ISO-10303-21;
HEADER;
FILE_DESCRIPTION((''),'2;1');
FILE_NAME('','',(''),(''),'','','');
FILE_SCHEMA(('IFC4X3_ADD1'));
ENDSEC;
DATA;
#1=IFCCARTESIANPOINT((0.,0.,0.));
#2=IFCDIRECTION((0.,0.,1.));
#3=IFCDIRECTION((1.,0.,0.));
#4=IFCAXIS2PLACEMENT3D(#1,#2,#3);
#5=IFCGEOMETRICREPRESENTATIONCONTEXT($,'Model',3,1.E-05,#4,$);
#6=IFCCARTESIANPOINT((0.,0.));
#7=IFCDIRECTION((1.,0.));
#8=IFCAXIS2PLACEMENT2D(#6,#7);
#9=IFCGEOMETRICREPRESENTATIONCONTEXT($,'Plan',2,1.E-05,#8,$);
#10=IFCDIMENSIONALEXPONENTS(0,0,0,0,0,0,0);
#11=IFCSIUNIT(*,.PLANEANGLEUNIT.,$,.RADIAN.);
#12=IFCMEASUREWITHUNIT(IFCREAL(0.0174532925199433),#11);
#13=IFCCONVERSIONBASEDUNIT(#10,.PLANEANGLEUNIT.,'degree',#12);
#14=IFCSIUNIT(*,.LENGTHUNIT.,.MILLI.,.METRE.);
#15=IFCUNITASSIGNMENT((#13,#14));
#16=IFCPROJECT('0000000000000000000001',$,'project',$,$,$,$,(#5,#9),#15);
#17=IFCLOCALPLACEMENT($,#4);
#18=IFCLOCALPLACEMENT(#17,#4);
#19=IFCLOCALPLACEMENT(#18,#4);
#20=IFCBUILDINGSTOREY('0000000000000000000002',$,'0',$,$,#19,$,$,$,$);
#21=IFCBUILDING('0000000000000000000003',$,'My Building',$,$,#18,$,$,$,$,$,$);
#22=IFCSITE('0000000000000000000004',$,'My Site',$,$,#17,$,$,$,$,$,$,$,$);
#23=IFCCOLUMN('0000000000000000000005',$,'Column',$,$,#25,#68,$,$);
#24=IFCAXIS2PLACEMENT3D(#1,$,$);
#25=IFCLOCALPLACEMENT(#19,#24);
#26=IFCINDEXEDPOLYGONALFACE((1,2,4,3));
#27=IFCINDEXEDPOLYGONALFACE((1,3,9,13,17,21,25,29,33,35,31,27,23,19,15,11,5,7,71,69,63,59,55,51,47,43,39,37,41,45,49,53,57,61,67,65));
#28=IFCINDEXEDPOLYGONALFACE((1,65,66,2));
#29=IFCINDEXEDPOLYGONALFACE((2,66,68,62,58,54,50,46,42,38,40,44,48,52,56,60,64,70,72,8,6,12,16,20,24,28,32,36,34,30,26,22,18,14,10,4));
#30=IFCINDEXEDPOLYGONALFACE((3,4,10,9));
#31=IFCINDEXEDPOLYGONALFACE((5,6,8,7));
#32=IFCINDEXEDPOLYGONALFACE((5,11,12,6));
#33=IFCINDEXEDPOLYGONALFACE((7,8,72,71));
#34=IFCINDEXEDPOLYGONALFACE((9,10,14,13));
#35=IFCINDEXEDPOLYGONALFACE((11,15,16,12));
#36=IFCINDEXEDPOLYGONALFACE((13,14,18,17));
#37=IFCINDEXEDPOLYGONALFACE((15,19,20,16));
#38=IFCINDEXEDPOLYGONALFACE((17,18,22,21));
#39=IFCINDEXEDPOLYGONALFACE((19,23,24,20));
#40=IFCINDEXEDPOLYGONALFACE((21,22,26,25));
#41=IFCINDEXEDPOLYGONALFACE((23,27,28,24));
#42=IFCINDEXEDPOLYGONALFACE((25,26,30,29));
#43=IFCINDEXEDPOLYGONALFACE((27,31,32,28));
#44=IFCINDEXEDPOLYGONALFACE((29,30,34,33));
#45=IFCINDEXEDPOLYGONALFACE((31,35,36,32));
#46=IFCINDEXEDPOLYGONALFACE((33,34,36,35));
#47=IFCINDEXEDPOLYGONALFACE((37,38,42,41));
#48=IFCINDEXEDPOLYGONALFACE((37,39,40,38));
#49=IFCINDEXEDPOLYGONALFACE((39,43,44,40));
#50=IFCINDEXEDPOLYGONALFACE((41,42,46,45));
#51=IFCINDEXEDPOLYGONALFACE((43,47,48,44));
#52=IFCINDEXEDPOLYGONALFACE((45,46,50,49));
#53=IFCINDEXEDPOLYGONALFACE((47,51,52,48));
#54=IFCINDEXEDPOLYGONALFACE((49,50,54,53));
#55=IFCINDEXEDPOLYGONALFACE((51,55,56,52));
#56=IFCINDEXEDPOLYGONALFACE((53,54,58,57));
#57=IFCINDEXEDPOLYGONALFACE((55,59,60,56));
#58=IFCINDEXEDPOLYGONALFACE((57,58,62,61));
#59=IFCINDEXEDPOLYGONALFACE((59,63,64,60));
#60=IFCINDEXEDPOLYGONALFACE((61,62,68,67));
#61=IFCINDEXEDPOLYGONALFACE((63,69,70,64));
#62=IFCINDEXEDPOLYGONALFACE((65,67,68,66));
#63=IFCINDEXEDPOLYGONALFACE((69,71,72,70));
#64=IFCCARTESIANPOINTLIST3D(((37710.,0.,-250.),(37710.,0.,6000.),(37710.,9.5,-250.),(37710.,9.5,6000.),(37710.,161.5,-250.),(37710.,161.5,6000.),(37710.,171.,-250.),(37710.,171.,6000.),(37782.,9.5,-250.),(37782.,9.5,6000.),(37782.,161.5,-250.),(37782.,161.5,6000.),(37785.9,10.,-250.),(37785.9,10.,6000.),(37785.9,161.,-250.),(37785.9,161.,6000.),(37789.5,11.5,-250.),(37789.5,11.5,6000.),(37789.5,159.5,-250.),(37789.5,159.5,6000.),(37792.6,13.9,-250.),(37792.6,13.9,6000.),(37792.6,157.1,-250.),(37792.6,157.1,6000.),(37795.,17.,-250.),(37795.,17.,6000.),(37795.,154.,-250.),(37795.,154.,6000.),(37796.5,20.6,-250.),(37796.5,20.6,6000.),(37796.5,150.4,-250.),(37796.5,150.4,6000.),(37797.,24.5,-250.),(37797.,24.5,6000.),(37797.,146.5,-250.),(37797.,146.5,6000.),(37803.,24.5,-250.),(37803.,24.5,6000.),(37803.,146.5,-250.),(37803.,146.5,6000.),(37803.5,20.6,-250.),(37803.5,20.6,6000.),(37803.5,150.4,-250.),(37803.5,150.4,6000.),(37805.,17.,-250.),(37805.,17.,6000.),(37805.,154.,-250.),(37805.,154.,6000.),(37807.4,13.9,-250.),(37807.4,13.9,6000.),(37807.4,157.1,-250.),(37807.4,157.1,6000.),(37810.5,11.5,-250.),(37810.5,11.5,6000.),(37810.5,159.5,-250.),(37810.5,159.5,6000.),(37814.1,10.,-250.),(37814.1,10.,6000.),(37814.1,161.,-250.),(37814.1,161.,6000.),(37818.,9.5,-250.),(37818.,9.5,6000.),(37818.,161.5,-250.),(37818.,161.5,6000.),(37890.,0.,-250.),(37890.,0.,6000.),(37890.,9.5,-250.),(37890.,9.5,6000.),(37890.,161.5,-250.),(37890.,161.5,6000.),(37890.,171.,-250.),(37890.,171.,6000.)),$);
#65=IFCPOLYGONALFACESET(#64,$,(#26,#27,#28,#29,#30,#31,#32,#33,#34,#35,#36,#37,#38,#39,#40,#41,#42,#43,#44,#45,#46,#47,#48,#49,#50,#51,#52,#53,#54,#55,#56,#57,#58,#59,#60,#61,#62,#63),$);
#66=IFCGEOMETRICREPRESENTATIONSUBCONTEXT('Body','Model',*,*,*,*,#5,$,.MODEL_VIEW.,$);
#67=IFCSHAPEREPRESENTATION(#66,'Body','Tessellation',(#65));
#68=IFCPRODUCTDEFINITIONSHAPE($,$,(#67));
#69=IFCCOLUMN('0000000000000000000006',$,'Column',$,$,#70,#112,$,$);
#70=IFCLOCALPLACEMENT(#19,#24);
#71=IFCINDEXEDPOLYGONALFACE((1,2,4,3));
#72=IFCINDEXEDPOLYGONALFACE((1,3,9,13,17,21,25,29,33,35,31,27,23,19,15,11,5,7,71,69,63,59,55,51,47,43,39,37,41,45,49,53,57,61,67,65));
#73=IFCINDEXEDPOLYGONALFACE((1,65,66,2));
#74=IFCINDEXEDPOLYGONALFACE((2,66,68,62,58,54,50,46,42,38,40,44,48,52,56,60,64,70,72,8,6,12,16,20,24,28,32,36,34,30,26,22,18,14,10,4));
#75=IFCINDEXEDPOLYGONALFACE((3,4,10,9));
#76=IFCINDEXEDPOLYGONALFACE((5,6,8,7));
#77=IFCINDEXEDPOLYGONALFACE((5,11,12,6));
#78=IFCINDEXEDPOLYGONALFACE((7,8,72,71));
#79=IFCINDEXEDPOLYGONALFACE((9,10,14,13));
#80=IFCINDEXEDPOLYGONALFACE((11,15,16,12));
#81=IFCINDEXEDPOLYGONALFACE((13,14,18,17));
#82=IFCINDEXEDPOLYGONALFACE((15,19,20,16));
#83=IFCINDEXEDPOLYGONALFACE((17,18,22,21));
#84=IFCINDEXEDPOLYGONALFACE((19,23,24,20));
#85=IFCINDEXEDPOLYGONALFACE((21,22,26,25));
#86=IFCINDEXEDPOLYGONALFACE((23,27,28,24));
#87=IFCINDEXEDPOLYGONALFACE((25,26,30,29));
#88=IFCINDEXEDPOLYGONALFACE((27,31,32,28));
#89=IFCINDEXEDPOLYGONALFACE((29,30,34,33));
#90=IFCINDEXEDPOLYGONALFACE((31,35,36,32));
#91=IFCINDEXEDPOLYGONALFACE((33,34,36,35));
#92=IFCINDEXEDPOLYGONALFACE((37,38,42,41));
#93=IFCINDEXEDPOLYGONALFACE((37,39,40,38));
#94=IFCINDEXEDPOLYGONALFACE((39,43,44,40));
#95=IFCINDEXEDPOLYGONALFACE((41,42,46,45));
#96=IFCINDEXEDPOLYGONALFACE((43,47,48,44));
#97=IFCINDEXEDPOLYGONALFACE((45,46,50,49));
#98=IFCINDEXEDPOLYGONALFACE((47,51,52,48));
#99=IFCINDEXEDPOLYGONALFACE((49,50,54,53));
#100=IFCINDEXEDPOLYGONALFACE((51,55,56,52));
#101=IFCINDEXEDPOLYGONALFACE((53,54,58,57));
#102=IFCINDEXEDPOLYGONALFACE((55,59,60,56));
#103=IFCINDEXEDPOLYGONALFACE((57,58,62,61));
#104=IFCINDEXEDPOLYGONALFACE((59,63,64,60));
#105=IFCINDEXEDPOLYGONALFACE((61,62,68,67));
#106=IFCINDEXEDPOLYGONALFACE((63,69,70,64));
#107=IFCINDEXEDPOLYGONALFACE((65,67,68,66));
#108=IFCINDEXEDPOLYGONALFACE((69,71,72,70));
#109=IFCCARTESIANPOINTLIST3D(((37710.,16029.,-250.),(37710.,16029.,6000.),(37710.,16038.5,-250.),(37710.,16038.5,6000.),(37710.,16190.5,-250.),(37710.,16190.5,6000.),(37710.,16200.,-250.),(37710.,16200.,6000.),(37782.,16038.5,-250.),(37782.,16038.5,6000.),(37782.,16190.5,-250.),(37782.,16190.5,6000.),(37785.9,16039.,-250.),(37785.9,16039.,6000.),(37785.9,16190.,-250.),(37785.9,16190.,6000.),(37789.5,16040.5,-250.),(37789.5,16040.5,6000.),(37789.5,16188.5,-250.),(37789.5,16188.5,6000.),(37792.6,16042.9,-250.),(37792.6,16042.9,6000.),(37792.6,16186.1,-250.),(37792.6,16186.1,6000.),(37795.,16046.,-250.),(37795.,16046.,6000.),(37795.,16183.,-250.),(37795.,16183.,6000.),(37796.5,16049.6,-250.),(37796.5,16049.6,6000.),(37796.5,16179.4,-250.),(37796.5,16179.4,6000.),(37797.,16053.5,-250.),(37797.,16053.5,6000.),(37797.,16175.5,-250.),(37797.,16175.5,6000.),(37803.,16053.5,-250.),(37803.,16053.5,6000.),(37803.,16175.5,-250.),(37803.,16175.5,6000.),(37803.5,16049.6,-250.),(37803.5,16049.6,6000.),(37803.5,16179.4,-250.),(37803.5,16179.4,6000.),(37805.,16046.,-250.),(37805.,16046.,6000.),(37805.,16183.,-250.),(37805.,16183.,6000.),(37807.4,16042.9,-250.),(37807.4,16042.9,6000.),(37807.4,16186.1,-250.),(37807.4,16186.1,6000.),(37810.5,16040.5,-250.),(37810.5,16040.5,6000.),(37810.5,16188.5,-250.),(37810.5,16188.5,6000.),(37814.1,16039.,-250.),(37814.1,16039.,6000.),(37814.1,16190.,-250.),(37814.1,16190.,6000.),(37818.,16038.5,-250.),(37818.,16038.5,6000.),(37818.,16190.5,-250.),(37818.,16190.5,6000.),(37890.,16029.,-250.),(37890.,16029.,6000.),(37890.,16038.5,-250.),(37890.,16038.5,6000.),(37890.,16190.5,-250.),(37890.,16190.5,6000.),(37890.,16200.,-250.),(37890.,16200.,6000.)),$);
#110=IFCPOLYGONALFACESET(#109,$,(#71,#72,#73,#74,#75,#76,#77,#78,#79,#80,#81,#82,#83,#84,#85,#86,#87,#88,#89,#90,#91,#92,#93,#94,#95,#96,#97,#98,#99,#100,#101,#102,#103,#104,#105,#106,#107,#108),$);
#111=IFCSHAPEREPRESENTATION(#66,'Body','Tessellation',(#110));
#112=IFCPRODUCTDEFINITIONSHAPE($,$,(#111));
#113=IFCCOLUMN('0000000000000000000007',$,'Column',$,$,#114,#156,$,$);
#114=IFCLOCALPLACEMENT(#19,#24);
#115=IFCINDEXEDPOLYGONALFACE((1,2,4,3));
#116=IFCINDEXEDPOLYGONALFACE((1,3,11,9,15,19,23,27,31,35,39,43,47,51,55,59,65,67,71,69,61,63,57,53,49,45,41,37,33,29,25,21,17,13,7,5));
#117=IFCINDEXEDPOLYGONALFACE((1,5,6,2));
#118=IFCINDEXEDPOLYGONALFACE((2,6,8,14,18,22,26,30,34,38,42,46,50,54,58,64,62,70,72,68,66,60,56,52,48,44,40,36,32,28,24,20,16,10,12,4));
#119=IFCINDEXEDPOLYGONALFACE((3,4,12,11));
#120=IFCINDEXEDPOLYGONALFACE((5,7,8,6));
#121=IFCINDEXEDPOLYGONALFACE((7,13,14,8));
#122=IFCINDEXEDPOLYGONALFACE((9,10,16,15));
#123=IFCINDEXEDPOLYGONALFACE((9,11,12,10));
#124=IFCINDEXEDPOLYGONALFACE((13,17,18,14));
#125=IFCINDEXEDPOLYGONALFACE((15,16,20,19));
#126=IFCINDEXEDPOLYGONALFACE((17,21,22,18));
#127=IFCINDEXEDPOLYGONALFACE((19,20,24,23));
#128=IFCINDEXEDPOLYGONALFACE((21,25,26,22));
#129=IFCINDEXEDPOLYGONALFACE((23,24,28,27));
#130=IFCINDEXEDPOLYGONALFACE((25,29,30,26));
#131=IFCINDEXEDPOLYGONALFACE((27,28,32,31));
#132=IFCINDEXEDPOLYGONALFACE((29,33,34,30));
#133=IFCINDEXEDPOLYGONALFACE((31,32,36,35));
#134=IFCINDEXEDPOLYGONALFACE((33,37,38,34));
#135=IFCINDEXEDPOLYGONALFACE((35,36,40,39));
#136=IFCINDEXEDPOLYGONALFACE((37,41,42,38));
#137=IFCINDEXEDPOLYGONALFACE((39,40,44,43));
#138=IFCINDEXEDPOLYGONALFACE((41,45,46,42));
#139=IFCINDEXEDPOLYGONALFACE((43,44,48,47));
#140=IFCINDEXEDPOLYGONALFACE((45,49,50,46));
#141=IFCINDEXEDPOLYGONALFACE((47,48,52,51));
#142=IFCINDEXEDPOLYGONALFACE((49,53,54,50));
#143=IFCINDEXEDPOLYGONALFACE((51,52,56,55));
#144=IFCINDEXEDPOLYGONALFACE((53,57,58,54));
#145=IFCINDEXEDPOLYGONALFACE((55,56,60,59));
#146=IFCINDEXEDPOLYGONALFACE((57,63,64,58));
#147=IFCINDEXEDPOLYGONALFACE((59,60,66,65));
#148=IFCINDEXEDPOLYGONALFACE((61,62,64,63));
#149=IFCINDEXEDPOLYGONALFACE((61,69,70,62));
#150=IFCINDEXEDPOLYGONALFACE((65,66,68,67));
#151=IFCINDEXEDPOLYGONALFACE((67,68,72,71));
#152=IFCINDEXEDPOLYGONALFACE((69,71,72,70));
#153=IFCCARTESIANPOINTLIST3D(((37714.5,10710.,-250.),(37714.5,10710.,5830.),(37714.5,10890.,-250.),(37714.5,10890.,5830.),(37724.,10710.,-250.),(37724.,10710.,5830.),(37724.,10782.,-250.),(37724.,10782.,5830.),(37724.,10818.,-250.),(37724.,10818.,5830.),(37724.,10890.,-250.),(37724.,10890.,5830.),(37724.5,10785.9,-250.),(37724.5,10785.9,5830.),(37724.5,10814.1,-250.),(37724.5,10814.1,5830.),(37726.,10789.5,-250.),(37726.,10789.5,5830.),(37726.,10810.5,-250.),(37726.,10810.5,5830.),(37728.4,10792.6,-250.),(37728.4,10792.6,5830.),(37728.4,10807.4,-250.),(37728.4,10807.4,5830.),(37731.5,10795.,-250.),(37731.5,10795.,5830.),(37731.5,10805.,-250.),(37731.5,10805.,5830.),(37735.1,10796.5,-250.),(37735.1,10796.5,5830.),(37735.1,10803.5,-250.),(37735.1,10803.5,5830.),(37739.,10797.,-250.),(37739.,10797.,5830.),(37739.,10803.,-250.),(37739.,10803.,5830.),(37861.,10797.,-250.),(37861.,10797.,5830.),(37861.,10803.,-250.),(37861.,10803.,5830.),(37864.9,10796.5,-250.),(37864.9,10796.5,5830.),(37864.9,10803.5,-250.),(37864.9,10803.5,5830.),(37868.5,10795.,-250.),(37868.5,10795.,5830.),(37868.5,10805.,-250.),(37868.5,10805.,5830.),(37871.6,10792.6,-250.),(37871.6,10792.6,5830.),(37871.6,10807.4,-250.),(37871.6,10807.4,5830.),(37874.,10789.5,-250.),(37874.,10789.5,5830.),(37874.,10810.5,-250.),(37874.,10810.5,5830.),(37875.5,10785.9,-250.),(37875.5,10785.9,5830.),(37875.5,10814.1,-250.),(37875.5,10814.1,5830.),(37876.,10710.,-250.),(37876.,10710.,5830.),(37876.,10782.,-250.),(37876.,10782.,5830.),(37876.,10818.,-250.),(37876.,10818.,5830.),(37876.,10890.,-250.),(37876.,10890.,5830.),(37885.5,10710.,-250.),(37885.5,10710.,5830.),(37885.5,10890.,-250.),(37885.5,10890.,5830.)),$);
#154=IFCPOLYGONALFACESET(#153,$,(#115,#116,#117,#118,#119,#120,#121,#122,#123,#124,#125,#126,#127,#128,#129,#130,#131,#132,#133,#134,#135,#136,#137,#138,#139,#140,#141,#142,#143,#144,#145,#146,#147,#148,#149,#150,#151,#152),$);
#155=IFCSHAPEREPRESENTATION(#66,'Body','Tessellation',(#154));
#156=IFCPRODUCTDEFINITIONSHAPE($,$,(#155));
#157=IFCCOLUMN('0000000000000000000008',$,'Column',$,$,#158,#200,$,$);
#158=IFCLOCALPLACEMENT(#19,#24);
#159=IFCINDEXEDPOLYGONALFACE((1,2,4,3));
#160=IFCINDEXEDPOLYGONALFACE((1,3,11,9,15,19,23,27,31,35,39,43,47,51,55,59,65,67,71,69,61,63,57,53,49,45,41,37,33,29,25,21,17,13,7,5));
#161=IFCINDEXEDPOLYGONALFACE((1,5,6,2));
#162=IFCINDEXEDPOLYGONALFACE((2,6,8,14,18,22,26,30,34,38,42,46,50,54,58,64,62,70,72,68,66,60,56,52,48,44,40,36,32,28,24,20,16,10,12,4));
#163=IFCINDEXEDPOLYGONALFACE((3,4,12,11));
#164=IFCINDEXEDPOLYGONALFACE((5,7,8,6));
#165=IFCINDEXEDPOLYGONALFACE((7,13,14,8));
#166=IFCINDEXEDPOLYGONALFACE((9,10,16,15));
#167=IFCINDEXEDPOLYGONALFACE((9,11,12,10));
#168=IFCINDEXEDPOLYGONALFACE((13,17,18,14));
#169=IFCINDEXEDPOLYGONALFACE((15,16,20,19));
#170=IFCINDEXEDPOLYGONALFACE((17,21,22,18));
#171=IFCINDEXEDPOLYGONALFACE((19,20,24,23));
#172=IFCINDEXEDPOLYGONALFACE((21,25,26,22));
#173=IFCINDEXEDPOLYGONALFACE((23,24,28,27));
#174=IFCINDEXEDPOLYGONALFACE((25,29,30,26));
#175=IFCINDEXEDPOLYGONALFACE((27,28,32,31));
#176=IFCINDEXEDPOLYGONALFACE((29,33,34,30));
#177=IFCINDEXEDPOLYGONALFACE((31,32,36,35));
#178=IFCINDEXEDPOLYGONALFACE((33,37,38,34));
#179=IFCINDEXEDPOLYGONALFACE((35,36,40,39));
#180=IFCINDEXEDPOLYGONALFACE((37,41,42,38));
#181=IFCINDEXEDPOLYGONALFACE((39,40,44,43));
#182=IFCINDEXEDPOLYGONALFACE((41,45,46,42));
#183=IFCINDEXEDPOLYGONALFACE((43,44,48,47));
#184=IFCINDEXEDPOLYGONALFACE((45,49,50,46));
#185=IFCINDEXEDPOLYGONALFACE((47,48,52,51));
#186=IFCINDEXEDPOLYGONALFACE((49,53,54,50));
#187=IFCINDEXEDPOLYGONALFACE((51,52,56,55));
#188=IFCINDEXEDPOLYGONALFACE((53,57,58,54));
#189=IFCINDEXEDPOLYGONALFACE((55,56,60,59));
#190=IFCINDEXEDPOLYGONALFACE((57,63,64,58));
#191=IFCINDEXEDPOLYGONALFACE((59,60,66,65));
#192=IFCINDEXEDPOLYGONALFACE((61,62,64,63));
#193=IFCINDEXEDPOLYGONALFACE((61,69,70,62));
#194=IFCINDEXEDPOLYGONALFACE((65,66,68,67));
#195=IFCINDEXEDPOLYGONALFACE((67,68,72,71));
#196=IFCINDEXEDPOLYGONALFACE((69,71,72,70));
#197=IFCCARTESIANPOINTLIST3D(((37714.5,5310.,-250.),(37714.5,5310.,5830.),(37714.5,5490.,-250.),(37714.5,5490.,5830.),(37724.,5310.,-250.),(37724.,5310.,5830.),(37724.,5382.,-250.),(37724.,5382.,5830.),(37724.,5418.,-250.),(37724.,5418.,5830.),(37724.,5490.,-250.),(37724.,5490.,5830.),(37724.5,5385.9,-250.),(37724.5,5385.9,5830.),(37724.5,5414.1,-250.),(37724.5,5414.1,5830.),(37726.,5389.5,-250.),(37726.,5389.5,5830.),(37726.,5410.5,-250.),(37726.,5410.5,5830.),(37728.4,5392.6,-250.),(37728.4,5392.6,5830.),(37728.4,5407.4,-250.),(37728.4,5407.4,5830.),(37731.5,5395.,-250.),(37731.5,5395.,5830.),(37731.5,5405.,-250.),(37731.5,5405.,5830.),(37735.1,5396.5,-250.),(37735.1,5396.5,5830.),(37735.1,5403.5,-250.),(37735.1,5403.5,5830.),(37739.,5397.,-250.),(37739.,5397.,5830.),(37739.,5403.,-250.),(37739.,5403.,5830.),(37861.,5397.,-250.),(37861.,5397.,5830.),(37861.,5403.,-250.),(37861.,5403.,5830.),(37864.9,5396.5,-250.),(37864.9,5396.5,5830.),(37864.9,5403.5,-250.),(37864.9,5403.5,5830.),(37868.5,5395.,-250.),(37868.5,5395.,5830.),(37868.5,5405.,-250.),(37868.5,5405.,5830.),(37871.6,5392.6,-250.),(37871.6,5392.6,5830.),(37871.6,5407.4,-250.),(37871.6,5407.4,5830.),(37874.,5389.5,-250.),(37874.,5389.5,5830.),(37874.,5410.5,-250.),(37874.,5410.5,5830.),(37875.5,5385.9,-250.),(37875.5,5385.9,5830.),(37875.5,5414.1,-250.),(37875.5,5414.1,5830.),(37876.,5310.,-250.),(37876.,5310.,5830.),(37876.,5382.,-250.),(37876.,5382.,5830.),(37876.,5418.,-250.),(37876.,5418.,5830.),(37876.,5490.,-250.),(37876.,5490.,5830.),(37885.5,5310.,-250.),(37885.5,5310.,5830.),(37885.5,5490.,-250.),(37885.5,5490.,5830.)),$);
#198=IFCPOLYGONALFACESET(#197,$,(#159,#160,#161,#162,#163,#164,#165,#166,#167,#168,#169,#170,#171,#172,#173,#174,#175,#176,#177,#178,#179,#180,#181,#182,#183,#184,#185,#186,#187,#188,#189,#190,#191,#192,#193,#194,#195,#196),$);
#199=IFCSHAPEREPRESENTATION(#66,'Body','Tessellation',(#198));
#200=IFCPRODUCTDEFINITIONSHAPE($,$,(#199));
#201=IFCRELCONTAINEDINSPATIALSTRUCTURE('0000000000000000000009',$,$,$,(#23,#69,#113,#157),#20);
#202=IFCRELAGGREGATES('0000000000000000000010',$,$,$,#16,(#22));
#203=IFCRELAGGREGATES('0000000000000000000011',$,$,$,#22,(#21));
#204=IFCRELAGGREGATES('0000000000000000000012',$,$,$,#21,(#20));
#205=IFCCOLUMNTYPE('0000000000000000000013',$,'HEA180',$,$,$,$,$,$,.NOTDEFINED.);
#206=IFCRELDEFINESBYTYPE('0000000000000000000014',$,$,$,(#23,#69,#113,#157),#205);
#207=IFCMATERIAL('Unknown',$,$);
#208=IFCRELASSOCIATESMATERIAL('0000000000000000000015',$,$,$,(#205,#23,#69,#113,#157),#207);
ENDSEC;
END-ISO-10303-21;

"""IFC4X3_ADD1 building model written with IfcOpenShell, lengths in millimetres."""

from ifc_helpers import new_model, entity, si_unit, converted_unit, frame, origin_with_axes, origin_2d_with_axis, place, context, subcontext, project, spatial, i_section, extrude, material, material_profile, profile_set, profile_usage, type_object, element, save


model = new_model("IFC4X3_ADD1")

# Units and contexts
model_context = context("Model", 3, precision=1e-05, world=origin_with_axes())
plan_context = context("Plan", 2, precision=1e-05, world=origin_2d_with_axis())
body_context = subcontext(model_context, "Body", "Model", "MODEL_VIEW")
ifc_project = project(units=[converted_unit("PLANEANGLEUNIT", "degree", entity("IfcReal", 0.0174532925199433), si_unit("PLANEANGLEUNIT", "RADIAN"), dimensions=[0, 0, 0, 0, 0, 0, 0]), si_unit("LENGTHUNIT", "METRE", prefix="MILLI")], contexts=[model_context, plan_context])

# Site, building, storey
site_placement = place(None, origin_with_axes())
site = spatial("IfcSite", under=ifc_project, at=site_placement, Name="My Site")
building_placement = place(site_placement, origin_with_axes())
building = spatial("IfcBuilding", under=site, at=building_placement, Name="My Building")
storey_placement = place(building_placement, origin_with_axes())
storey = spatial("IfcBuildingStorey", under=building, at=storey_placement, Name="0")

# Columns
ifc_material = material(Name="Unknown")
ifc_material_profile_1 = material_profile(ifc_material, i_section(OverallWidth=180.0, OverallDepth=171.0, WebThickness=6.0, FlangeThickness=9.5, FilletRadius=15.0))
ifc_profile_set_1 = profile_set([ifc_material_profile_1])
column_type = type_object("IfcColumnType", Name="HEA180", PredefinedType="NOTDEFINED", material=ifc_profile_set_1)
ifc_profile_usage_1 = profile_usage(ifc_profile_set_1, cardinal=2)
column_1_placement = place(storey_placement, frame((37800.0, 0.0, -250.0), z_axis=(0.0, 0.0, 1.0), x_axis=(1.0, 0.0, 0.0)))
element("IfcColumn", 1, at=column_1_placement, inside=storey, type_object=column_type, material=ifc_profile_usage_1, Name="Column", context=body_context, shape_type="SweptSolid", body=[
    extrude(i_section(OverallWidth=180.0, OverallDepth=171.0, WebThickness=6.0, FlangeThickness=9.5, FilletRadius=15.0), frame((0.0, 85.5, 0.0), z_axis=(0.0, 0.0, 1.0), x_axis=(1.0, 0.0, 0.0)), (0.0, 0.0, 1.0), 6250.0),
])
ifc_profile_usage_2 = profile_usage(ifc_profile_set_1, cardinal=8)
column_2_placement = place(storey_placement, frame((37800.0, 16200.0, -250.0), z_axis=(0.0, 0.0, 1.0), x_axis=(1.0, 0.0, 0.0)))
element("IfcColumn", 2, at=column_2_placement, inside=storey, type_object=column_type, material=ifc_profile_usage_2, Name="Column", context=body_context, shape_type="SweptSolid", body=[
    extrude(i_section(OverallWidth=180.0, OverallDepth=171.0, WebThickness=6.0, FlangeThickness=9.5, FilletRadius=15.0), frame((0.0, -85.5, 0.0), z_axis=(0.0, 0.0, 1.0), x_axis=(1.0, 0.0, 0.0)), (0.0, 0.0, 1.0), 6250.0),
])
ifc_profile_usage_3 = profile_usage(ifc_profile_set_1, cardinal=10)
column_3_placement = place(storey_placement, frame((37800.0, 10800.0, -250.0), z_axis=(0.0, 0.0, 1.0), x_axis=(0.0, 1.0, 0.0)))
element("IfcColumn", 3, at=column_3_placement, inside=storey, type_object=column_type, material=ifc_profile_usage_3, Name="Column", context=body_context, shape_type="SweptSolid", body=[
    extrude(i_section(OverallWidth=180.0, OverallDepth=171.0, WebThickness=6.0, FlangeThickness=9.5, FilletRadius=15.0), origin_with_axes(), (0.0, 0.0, 1.0), 6080.0),
])
ifc_profile_usage_4 = profile_usage(ifc_profile_set_1, cardinal=10)
column_4_placement = place(storey_placement, frame((37800.0, 5400.0, -250.0), z_axis=(0.0, 0.0, 1.0), x_axis=(0.0, 1.0, 0.0)))
element("IfcColumn", 4, at=column_4_placement, inside=storey, type_object=column_type, material=ifc_profile_usage_4, Name="Column", context=body_context, shape_type="SweptSolid", body=[
    extrude(i_section(OverallWidth=180.0, OverallDepth=171.0, WebThickness=6.0, FlangeThickness=9.5, FilletRadius=15.0), origin_with_axes(), (0.0, 0.0, 1.0), 6080.0),
])

save(model, "model.ifc")
